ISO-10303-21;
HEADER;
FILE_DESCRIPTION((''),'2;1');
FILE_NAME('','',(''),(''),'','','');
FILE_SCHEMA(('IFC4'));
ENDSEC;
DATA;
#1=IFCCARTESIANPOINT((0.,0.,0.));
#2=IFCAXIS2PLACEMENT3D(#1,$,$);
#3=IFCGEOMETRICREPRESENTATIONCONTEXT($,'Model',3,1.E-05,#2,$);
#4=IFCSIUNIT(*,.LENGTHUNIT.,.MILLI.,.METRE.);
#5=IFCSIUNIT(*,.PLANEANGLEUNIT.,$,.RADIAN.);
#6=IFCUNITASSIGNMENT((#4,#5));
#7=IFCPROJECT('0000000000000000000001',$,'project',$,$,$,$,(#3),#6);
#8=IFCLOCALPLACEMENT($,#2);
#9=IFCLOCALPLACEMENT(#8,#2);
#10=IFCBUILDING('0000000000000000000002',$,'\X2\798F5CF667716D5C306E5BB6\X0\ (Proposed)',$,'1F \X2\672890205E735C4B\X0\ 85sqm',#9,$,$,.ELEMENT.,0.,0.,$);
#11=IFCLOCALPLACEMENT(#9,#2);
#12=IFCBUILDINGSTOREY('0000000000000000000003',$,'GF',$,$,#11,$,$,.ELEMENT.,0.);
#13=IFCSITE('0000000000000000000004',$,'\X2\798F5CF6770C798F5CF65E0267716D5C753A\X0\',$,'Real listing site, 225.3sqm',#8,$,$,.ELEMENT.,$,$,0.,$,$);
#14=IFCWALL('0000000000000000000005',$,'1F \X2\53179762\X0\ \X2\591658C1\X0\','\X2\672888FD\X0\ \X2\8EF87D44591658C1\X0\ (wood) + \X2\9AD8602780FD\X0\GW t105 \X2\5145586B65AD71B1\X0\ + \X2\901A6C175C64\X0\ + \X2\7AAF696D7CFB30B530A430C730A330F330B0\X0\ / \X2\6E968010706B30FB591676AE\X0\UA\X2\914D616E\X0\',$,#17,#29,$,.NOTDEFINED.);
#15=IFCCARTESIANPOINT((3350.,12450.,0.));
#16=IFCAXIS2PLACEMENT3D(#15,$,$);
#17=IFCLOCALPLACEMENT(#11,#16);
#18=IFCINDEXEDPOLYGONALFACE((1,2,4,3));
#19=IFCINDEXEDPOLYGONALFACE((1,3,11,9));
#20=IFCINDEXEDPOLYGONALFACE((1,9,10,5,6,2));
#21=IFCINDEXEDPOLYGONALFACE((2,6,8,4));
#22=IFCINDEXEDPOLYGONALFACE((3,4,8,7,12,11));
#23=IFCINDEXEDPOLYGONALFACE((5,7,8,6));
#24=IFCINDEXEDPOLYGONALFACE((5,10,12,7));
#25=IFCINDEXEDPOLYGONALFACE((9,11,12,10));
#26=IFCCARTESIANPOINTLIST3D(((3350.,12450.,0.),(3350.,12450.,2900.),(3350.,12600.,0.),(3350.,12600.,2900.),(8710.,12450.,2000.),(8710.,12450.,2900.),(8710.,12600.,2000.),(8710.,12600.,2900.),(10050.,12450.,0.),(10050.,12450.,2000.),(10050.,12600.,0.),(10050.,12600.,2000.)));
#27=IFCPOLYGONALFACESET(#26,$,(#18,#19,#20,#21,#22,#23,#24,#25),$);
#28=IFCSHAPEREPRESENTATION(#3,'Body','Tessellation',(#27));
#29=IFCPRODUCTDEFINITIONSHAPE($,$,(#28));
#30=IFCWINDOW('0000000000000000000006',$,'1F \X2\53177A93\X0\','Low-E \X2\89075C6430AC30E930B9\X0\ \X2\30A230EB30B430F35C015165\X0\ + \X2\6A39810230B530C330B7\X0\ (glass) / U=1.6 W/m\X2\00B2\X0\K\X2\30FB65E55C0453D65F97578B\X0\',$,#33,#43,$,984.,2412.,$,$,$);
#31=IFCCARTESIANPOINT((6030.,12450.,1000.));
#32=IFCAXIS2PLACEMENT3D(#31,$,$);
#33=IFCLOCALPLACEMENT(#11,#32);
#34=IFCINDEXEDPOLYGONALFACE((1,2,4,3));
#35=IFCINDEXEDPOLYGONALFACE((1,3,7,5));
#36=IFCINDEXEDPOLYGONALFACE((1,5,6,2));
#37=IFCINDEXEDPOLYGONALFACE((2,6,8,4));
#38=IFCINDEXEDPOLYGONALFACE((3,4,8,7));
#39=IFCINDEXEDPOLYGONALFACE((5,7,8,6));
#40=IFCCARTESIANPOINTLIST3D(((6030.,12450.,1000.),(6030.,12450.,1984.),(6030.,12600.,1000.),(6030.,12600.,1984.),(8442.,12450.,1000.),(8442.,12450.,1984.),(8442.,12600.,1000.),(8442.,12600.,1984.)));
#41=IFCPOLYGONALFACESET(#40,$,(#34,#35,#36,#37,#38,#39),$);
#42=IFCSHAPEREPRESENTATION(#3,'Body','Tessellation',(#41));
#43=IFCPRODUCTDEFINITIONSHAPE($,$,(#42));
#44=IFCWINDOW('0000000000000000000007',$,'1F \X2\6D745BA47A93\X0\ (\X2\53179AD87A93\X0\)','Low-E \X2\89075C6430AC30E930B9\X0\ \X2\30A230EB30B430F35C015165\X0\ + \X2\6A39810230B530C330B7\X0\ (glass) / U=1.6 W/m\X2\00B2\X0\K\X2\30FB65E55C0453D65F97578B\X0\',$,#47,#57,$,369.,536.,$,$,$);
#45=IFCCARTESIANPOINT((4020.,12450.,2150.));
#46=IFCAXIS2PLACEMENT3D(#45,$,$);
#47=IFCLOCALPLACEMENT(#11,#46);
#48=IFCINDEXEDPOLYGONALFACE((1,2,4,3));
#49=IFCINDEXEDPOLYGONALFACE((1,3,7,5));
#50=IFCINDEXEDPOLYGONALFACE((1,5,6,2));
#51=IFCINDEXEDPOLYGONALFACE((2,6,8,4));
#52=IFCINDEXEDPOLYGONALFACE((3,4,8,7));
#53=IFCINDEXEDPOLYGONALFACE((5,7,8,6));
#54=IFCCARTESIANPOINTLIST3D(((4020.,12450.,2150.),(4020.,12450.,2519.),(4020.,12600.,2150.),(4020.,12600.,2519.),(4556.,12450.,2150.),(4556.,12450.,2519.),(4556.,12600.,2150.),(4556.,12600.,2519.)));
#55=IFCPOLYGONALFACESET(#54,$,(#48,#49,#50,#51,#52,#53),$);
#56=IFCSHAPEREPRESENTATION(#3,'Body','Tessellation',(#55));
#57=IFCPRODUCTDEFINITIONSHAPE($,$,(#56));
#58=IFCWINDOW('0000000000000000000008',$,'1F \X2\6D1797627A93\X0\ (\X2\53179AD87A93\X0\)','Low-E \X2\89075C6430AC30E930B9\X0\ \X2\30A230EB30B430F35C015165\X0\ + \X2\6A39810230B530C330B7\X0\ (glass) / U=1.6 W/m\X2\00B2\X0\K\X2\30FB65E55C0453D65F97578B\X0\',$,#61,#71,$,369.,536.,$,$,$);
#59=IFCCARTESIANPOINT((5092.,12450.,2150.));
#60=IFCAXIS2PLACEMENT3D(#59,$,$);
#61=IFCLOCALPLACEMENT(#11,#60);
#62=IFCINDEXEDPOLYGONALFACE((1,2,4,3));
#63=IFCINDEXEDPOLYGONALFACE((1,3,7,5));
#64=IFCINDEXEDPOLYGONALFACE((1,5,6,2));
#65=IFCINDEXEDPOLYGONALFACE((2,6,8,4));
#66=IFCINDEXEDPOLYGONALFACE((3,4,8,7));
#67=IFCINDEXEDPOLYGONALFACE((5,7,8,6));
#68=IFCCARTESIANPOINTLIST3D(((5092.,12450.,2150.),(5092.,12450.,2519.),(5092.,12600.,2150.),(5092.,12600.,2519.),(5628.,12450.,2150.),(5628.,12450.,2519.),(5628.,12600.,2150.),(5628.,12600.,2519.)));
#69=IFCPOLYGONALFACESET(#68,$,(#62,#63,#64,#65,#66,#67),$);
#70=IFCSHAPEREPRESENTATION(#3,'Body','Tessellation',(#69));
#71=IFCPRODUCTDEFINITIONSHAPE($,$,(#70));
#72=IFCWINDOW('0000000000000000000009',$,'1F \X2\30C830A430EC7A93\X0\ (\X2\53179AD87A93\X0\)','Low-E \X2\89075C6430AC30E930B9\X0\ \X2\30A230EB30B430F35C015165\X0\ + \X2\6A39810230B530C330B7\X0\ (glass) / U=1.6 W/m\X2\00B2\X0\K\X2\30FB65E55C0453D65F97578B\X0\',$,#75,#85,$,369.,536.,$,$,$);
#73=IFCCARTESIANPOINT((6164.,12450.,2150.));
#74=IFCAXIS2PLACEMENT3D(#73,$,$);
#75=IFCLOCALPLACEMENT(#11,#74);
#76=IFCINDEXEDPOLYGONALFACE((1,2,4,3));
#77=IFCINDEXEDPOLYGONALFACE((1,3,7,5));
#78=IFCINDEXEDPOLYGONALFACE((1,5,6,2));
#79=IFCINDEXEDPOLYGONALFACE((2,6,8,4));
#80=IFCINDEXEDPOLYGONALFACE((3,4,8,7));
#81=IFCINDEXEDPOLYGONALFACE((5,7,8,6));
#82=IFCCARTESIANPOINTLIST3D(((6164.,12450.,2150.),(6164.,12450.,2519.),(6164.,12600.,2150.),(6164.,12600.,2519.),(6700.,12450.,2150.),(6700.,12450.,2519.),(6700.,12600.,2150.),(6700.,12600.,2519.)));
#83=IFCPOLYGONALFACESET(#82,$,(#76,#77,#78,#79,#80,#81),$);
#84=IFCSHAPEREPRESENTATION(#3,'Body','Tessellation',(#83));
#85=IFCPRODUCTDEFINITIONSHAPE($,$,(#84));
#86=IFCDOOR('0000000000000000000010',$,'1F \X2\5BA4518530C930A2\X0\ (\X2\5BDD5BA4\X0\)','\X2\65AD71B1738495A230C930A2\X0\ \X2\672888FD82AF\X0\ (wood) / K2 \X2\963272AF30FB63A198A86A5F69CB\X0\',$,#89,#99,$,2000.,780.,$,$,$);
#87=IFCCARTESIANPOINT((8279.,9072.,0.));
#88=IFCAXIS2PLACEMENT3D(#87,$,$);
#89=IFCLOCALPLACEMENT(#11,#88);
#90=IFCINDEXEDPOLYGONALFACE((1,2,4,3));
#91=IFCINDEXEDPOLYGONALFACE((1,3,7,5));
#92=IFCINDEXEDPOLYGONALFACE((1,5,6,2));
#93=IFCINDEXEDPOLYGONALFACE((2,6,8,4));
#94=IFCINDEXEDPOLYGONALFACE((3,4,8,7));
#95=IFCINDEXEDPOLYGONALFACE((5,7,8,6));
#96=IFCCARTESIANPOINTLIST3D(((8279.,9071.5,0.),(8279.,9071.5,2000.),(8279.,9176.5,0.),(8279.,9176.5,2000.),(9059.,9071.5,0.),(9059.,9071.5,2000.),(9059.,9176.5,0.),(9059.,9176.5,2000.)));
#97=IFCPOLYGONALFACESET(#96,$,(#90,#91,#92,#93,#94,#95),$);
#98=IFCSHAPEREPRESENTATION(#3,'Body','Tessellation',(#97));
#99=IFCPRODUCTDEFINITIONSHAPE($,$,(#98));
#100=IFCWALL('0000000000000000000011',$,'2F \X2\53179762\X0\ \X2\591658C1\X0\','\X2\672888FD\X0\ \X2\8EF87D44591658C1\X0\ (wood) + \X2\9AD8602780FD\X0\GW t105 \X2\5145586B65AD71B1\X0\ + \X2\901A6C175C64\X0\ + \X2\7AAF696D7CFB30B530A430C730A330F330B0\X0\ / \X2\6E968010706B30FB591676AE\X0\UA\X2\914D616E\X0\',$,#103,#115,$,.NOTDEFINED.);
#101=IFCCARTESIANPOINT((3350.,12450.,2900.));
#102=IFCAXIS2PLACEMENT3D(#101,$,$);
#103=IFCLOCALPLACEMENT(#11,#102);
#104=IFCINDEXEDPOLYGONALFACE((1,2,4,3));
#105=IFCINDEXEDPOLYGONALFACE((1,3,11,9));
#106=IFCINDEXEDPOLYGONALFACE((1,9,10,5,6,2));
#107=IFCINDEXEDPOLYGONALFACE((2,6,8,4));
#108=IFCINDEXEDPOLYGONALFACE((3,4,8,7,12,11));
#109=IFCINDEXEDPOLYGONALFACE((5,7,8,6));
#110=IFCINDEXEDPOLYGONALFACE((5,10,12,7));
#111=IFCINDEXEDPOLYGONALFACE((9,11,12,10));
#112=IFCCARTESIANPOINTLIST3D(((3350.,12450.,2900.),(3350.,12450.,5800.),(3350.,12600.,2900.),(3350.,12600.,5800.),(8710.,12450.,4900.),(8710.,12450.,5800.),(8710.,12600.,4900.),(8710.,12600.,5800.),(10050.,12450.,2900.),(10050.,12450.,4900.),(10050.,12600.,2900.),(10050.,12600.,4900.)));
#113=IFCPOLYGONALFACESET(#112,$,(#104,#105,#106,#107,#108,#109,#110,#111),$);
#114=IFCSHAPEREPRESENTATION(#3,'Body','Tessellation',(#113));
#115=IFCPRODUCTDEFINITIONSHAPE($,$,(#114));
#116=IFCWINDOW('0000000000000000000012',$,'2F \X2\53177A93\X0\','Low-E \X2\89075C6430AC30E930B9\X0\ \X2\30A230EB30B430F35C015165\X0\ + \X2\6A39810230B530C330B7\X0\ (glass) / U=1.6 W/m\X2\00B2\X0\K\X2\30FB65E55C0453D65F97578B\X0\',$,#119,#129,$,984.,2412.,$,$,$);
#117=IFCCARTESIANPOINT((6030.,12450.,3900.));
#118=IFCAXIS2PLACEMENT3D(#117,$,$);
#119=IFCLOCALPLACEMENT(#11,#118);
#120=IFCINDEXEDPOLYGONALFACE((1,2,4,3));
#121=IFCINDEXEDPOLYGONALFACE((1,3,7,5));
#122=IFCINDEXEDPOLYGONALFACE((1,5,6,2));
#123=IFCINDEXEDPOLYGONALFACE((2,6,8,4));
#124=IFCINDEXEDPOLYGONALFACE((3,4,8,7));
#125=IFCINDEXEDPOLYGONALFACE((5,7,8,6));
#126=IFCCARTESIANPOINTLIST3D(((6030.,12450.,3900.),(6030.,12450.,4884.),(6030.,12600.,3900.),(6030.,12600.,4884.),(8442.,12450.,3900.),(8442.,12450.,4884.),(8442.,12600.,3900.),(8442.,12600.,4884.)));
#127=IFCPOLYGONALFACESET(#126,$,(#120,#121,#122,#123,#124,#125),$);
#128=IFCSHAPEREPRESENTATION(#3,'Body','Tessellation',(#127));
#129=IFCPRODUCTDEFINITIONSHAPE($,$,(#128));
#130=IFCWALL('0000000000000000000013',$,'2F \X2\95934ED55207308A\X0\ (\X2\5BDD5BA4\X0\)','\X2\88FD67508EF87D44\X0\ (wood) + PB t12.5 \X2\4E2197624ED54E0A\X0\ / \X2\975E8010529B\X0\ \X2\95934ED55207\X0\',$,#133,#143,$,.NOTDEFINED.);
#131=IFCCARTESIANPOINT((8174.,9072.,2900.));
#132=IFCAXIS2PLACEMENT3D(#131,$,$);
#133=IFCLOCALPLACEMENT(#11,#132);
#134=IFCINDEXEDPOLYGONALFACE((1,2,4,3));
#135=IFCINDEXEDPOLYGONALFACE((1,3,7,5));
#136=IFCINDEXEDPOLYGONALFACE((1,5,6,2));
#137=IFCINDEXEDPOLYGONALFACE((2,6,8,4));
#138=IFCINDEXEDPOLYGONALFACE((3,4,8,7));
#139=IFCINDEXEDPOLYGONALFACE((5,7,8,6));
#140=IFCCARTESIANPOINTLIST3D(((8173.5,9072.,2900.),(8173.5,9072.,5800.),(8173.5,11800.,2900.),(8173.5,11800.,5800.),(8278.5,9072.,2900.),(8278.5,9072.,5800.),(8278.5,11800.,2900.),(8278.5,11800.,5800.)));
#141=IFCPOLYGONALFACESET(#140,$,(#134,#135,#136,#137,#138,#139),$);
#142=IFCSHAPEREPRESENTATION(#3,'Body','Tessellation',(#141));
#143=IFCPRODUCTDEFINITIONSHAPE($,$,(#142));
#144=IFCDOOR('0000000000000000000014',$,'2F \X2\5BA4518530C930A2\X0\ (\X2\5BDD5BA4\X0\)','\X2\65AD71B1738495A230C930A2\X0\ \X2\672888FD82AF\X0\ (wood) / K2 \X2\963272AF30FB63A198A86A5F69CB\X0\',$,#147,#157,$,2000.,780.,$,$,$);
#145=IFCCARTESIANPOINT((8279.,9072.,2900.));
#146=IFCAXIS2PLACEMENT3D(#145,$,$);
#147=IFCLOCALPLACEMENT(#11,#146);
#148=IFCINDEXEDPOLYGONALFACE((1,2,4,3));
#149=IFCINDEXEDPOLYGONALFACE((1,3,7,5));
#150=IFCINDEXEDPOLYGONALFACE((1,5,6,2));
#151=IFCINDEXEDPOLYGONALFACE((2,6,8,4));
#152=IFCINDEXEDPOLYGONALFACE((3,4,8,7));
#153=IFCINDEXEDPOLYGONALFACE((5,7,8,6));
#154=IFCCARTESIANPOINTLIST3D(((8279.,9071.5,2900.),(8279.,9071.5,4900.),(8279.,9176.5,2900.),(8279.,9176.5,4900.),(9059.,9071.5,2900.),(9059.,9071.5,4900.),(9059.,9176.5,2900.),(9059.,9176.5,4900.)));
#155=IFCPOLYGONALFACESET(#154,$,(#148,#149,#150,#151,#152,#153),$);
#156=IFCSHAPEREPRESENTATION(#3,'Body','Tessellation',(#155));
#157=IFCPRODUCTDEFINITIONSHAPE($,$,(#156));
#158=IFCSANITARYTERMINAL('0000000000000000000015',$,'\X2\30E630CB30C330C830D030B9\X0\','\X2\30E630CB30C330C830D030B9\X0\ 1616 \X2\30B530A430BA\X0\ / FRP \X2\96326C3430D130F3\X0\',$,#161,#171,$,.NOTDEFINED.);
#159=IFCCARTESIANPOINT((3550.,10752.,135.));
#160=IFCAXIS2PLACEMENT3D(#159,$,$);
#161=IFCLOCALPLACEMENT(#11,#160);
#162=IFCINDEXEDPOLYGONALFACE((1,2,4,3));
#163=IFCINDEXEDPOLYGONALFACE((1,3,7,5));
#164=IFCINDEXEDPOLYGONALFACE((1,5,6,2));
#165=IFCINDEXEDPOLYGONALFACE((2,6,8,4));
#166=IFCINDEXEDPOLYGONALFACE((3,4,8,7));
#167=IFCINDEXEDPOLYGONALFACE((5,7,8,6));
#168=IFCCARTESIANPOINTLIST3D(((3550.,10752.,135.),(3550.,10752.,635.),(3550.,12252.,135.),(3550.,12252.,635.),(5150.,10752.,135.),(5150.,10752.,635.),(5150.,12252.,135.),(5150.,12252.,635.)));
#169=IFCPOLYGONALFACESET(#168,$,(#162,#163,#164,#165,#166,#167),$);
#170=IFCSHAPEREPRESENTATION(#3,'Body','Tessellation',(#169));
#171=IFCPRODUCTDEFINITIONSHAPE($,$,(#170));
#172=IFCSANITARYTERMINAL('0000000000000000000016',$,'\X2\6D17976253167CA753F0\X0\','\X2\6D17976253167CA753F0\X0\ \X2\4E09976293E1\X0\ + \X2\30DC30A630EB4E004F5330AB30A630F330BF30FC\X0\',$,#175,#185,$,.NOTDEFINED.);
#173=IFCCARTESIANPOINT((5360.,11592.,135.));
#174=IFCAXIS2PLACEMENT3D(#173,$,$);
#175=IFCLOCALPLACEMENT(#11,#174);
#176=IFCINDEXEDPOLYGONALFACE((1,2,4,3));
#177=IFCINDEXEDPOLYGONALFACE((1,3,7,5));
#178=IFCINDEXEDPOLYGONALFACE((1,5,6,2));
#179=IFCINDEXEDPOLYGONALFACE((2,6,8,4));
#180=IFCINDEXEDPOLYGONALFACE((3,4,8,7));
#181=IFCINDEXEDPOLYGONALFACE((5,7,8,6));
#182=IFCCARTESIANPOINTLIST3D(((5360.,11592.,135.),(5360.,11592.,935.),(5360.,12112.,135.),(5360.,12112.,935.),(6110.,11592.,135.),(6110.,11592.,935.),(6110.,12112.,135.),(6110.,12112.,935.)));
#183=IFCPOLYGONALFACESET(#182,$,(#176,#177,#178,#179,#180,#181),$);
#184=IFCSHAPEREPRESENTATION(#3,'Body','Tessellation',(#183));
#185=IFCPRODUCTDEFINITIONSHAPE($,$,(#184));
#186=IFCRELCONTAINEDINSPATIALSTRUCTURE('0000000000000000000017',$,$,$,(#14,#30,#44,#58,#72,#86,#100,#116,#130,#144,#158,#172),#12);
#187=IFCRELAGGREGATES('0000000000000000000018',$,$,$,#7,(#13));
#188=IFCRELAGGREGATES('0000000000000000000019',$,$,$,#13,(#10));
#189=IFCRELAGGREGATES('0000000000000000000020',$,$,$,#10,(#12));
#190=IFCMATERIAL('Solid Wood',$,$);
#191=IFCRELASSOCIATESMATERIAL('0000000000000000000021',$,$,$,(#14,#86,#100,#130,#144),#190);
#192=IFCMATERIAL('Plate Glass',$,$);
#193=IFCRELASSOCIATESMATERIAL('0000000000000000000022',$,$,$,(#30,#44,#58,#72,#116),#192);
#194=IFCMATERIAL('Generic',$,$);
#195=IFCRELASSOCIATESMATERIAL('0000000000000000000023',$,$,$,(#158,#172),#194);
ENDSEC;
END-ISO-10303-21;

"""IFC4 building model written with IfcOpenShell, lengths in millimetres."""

from ifc_helpers import new_model, si_unit, frame, frame_2d, origin, place, context, project, spatial, rectangle, extrude, material, element, fill, save


model = new_model("IFC4")

# Units and contexts
model_context = context("Model", 3, precision=1e-05, world=origin())
ifc_project = project(units=[si_unit("LENGTHUNIT", "METRE", prefix="MILLI"), si_unit("PLANEANGLEUNIT", "RADIAN")], contexts=[model_context])

# Site, building, storey
site_placement = place(None, origin())
site = spatial("IfcSite", under=ifc_project, at=site_placement, Name="福島県福島市東浜町", ObjectType="Real listing site, 225.3sqm", CompositionType="ELEMENT", RefElevation=0.0)
building_placement = place(site_placement, origin())
building = spatial("IfcBuilding", under=site, at=building_placement, Name="福島東浜の家 (Proposed)", ObjectType="1F 木造平屋 85sqm", CompositionType="ELEMENT", ElevationOfRefHeight=0.0, ElevationOfTerrain=0.0)
storey_placement = place(building_placement, origin())
storey = spatial("IfcBuildingStorey", under=building, at=storey_placement, Name="GF", CompositionType="ELEMENT", Elevation=0.0)

# Wall, openings, windows
ifc_material_1 = material(Name="Solid Wood")
wall_1_placement = place(storey_placement, frame((3350.0, 12450.0, 0.0)))
wall_1 = element("IfcWall", 1, at=wall_1_placement, inside=storey, material=ifc_material_1, Name="1F 北面 外壁", Description="木製 軸組外壁 (wood) + 高性能GW t105 充填断熱 + 通気層 + 窯業系サイディング / 準耐火・外皮UA配慮", PredefinedType="NOTDEFINED", context=model_context, shape_type="SweptSolid", body=[
    extrude(rectangle(XDim=6700.0, YDim=150.0, at=frame_2d((3350.0, 75.0))), frame((3350.0, 12450.0, 0.0)), (0.0, 0.0, 1.0), 2900.0),
])
opening_1_placement = place(storey_placement, frame((6030.0, 12450.0, 1000.0)))
opening_1 = element("IfcOpeningElement", 2, at=opening_1_placement, cuts=wall_1, PredefinedType="NOTDEFINED", context=model_context, shape_type="SweptSolid", body=[
    extrude(rectangle(XDim=2412.0, YDim=150.0, at=frame_2d((1206.0, 75.0))), frame((6030.0, 12450.0, 1000.0)), (0.0, 0.0, 1.0), 984.0),
])
opening_2_placement = place(storey_placement, frame((4020.0, 12450.0, 2150.0)))
opening_2 = element("IfcOpeningElement", 3, at=opening_2_placement, cuts=wall_1, PredefinedType="NOTDEFINED", context=model_context, shape_type="SweptSolid", body=[
    extrude(rectangle(XDim=536.0, YDim=150.0, at=frame_2d((268.0, 75.0))), frame((4020.0, 12450.0, 2150.0)), (0.0, 0.0, 1.0), 369.0),
])
opening_3_placement = place(storey_placement, frame((5092.0, 12450.0, 2150.0)))
opening_3 = element("IfcOpeningElement", 4, at=opening_3_placement, cuts=wall_1, PredefinedType="NOTDEFINED", context=model_context, shape_type="SweptSolid", body=[
    extrude(rectangle(XDim=536.0, YDim=150.0, at=frame_2d((268.0, 75.0))), frame((5092.0, 12450.0, 2150.0)), (0.0, 0.0, 1.0), 369.0),
])
opening_4_placement = place(storey_placement, frame((6164.0, 12450.0, 2150.0)))
opening_4 = element("IfcOpeningElement", 5, at=opening_4_placement, cuts=wall_1, PredefinedType="NOTDEFINED", context=model_context, shape_type="SweptSolid", body=[
    extrude(rectangle(XDim=536.0, YDim=150.0, at=frame_2d((268.0, 75.0))), frame((6164.0, 12450.0, 2150.0)), (0.0, 0.0, 1.0), 369.0),
])
ifc_material_2 = material(Name="Plate Glass")
window_1_placement = place(storey_placement, frame((6030.0, 12450.0, 1000.0)))
window_1 = element("IfcWindow", 6, at=window_1_placement, inside=storey, material=ifc_material_2, Name="1F 北窓", Description="Low-E 複層ガラス アルゴン封入 + 樹脂サッシ (glass) / U=1.6 W/m²K・日射取得型", OverallHeight=984.0, OverallWidth=2412.0, context=model_context, shape_type="SweptSolid", body=[
    extrude(rectangle(XDim=2412.0, YDim=150.0, at=frame_2d((1206.0, 75.0))), frame((6030.0, 12450.0, 1000.0)), (0.0, 0.0, 1.0), 984.0),
])
fill(opening_1, window_1)
window_2_placement = place(storey_placement, frame((4020.0, 12450.0, 2150.0)))
window_2 = element("IfcWindow", 7, at=window_2_placement, inside=storey, material=ifc_material_2, Name="1F 浴室窓 (北高窓)", Description="Low-E 複層ガラス アルゴン封入 + 樹脂サッシ (glass) / U=1.6 W/m²K・日射取得型", OverallHeight=369.0, OverallWidth=536.0, context=model_context, shape_type="SweptSolid", body=[
    extrude(rectangle(XDim=536.0, YDim=150.0, at=frame_2d((268.0, 75.0))), frame((4020.0, 12450.0, 2150.0)), (0.0, 0.0, 1.0), 369.0),
])
fill(opening_2, window_2)
window_3_placement = place(storey_placement, frame((5092.0, 12450.0, 2150.0)))
window_3 = element("IfcWindow", 8, at=window_3_placement, inside=storey, material=ifc_material_2, Name="1F 洗面窓 (北高窓)", Description="Low-E 複層ガラス アルゴン封入 + 樹脂サッシ (glass) / U=1.6 W/m²K・日射取得型", OverallHeight=369.0, OverallWidth=536.0, context=model_context, shape_type="SweptSolid", body=[
    extrude(rectangle(XDim=536.0, YDim=150.0, at=frame_2d((268.0, 75.0))), frame((5092.0, 12450.0, 2150.0)), (0.0, 0.0, 1.0), 369.0),
])
fill(opening_3, window_3)
window_4_placement = place(storey_placement, frame((6164.0, 12450.0, 2150.0)))
window_4 = element("IfcWindow", 9, at=window_4_placement, inside=storey, material=ifc_material_2, Name="1F トイレ窓 (北高窓)", Description="Low-E 複層ガラス アルゴン封入 + 樹脂サッシ (glass) / U=1.6 W/m²K・日射取得型", OverallHeight=369.0, OverallWidth=536.0, context=model_context, shape_type="SweptSolid", body=[
    extrude(rectangle(XDim=536.0, YDim=150.0, at=frame_2d((268.0, 75.0))), frame((6164.0, 12450.0, 2150.0)), (0.0, 0.0, 1.0), 369.0),
])
fill(opening_4, window_4)

# Door
door_1_placement = place(storey_placement, frame((8279.0, 9072.0, 0.0)))
element("IfcDoor", 10, at=door_1_placement, inside=storey, material=ifc_material_1, Name="1F 室内ドア (寝室)", Description="断熱玄関ドア 木製芯 (wood) / K2 防犯・採風機構", OverallHeight=2000.0, OverallWidth=780.0, context=model_context, shape_type="SweptSolid", body=[
    extrude(rectangle(XDim=780.0, YDim=105.0, at=frame_2d((390.0, 52.0))), frame((8279.0, 9072.0, 0.0)), (0.0, 0.0, 1.0), 2000.0),
])

# Wall, opening, window
wall_2_placement = place(storey_placement, frame((3350.0, 12450.0, 2900.0)))
wall_2 = element("IfcWall", 11, at=wall_2_placement, inside=storey, material=ifc_material_1, Name="2F 北面 外壁", Description="木製 軸組外壁 (wood) + 高性能GW t105 充填断熱 + 通気層 + 窯業系サイディング / 準耐火・外皮UA配慮", PredefinedType="NOTDEFINED", context=model_context, shape_type="SweptSolid", body=[
    extrude(rectangle(XDim=6700.0, YDim=150.0, at=frame_2d((3350.0, 75.0))), frame((3350.0, 12450.0, 2900.0)), (0.0, 0.0, 1.0), 2900.0),
])
opening_5_placement = place(storey_placement, frame((6030.0, 12450.0, 3900.0)))
opening_5 = element("IfcOpeningElement", 12, at=opening_5_placement, cuts=wall_2, PredefinedType="NOTDEFINED", context=model_context, shape_type="SweptSolid", body=[
    extrude(rectangle(XDim=2412.0, YDim=150.0, at=frame_2d((1206.0, 75.0))), frame((6030.0, 12450.0, 3900.0)), (0.0, 0.0, 1.0), 984.0),
])
window_5_placement = place(storey_placement, frame((6030.0, 12450.0, 3900.0)))
window_5 = element("IfcWindow", 13, at=window_5_placement, inside=storey, material=ifc_material_2, Name="2F 北窓", Description="Low-E 複層ガラス アルゴン封入 + 樹脂サッシ (glass) / U=1.6 W/m²K・日射取得型", OverallHeight=984.0, OverallWidth=2412.0, context=model_context, shape_type="SweptSolid", body=[
    extrude(rectangle(XDim=2412.0, YDim=150.0, at=frame_2d((1206.0, 75.0))), frame((6030.0, 12450.0, 3900.0)), (0.0, 0.0, 1.0), 984.0),
])
fill(opening_5, window_5)

# Wall
wall_3_placement = place(storey_placement, frame((8174.0, 9072.0, 2900.0)))
element("IfcWall", 14, at=wall_3_placement, inside=storey, material=ifc_material_1, Name="2F 間仕切り (寝室)", Description="製材軸組 (wood) + PB t12.5 両面仕上 / 非耐力 間仕切", PredefinedType="NOTDEFINED", context=model_context, shape_type="SweptSolid", body=[
    extrude(rectangle(XDim=105.0, YDim=2728.0, at=frame_2d((52.0, 1364.0))), frame((8174.0, 9072.0, 2900.0)), (0.0, 0.0, 1.0), 2900.0),
])

# Door
door_2_placement = place(storey_placement, frame((8279.0, 9072.0, 2900.0)))
element("IfcDoor", 15, at=door_2_placement, inside=storey, material=ifc_material_1, Name="2F 室内ドア (寝室)", Description="断熱玄関ドア 木製芯 (wood) / K2 防犯・採風機構", OverallHeight=2000.0, OverallWidth=780.0, context=model_context, shape_type="SweptSolid", body=[
    extrude(rectangle(XDim=780.0, YDim=105.0, at=frame_2d((390.0, 52.0))), frame((8279.0, 9072.0, 2900.0)), (0.0, 0.0, 1.0), 2000.0),
])

# Sanitary terminals
ifc_material_3 = material(Name="Generic")
sanitary_terminal_1_placement = place(storey_placement, frame((3550.0, 10752.0, 135.0)))
element("IfcSanitaryTerminal", 16, at=sanitary_terminal_1_placement, inside=storey, material=ifc_material_3, Name="ユニットバス", Description="ユニットバス 1616 サイズ / FRP 防水パン", PredefinedType="NOTDEFINED", context=model_context, shape_type="SweptSolid", body=[
    extrude(rectangle(XDim=1600.0, YDim=1500.0, at=frame_2d((800.0, 750.0))), frame((3550.0, 10752.0, 135.0)), (0.0, 0.0, 1.0), 500.0),
])
sanitary_terminal_2_placement = place(storey_placement, frame((5360.0, 11592.0, 135.0)))
element("IfcSanitaryTerminal", 17, at=sanitary_terminal_2_placement, inside=storey, material=ifc_material_3, Name="洗面化粧台", Description="洗面化粧台 三面鏡 + ボウル一体カウンター", PredefinedType="NOTDEFINED", context=model_context, shape_type="SweptSolid", body=[
    extrude(rectangle(XDim=750.0, YDim=520.0, at=frame_2d((375.0, 260.0))), frame((5360.0, 11592.0, 135.0)), (0.0, 0.0, 1.0), 800.0),
])

save(model, "model.ifc")
